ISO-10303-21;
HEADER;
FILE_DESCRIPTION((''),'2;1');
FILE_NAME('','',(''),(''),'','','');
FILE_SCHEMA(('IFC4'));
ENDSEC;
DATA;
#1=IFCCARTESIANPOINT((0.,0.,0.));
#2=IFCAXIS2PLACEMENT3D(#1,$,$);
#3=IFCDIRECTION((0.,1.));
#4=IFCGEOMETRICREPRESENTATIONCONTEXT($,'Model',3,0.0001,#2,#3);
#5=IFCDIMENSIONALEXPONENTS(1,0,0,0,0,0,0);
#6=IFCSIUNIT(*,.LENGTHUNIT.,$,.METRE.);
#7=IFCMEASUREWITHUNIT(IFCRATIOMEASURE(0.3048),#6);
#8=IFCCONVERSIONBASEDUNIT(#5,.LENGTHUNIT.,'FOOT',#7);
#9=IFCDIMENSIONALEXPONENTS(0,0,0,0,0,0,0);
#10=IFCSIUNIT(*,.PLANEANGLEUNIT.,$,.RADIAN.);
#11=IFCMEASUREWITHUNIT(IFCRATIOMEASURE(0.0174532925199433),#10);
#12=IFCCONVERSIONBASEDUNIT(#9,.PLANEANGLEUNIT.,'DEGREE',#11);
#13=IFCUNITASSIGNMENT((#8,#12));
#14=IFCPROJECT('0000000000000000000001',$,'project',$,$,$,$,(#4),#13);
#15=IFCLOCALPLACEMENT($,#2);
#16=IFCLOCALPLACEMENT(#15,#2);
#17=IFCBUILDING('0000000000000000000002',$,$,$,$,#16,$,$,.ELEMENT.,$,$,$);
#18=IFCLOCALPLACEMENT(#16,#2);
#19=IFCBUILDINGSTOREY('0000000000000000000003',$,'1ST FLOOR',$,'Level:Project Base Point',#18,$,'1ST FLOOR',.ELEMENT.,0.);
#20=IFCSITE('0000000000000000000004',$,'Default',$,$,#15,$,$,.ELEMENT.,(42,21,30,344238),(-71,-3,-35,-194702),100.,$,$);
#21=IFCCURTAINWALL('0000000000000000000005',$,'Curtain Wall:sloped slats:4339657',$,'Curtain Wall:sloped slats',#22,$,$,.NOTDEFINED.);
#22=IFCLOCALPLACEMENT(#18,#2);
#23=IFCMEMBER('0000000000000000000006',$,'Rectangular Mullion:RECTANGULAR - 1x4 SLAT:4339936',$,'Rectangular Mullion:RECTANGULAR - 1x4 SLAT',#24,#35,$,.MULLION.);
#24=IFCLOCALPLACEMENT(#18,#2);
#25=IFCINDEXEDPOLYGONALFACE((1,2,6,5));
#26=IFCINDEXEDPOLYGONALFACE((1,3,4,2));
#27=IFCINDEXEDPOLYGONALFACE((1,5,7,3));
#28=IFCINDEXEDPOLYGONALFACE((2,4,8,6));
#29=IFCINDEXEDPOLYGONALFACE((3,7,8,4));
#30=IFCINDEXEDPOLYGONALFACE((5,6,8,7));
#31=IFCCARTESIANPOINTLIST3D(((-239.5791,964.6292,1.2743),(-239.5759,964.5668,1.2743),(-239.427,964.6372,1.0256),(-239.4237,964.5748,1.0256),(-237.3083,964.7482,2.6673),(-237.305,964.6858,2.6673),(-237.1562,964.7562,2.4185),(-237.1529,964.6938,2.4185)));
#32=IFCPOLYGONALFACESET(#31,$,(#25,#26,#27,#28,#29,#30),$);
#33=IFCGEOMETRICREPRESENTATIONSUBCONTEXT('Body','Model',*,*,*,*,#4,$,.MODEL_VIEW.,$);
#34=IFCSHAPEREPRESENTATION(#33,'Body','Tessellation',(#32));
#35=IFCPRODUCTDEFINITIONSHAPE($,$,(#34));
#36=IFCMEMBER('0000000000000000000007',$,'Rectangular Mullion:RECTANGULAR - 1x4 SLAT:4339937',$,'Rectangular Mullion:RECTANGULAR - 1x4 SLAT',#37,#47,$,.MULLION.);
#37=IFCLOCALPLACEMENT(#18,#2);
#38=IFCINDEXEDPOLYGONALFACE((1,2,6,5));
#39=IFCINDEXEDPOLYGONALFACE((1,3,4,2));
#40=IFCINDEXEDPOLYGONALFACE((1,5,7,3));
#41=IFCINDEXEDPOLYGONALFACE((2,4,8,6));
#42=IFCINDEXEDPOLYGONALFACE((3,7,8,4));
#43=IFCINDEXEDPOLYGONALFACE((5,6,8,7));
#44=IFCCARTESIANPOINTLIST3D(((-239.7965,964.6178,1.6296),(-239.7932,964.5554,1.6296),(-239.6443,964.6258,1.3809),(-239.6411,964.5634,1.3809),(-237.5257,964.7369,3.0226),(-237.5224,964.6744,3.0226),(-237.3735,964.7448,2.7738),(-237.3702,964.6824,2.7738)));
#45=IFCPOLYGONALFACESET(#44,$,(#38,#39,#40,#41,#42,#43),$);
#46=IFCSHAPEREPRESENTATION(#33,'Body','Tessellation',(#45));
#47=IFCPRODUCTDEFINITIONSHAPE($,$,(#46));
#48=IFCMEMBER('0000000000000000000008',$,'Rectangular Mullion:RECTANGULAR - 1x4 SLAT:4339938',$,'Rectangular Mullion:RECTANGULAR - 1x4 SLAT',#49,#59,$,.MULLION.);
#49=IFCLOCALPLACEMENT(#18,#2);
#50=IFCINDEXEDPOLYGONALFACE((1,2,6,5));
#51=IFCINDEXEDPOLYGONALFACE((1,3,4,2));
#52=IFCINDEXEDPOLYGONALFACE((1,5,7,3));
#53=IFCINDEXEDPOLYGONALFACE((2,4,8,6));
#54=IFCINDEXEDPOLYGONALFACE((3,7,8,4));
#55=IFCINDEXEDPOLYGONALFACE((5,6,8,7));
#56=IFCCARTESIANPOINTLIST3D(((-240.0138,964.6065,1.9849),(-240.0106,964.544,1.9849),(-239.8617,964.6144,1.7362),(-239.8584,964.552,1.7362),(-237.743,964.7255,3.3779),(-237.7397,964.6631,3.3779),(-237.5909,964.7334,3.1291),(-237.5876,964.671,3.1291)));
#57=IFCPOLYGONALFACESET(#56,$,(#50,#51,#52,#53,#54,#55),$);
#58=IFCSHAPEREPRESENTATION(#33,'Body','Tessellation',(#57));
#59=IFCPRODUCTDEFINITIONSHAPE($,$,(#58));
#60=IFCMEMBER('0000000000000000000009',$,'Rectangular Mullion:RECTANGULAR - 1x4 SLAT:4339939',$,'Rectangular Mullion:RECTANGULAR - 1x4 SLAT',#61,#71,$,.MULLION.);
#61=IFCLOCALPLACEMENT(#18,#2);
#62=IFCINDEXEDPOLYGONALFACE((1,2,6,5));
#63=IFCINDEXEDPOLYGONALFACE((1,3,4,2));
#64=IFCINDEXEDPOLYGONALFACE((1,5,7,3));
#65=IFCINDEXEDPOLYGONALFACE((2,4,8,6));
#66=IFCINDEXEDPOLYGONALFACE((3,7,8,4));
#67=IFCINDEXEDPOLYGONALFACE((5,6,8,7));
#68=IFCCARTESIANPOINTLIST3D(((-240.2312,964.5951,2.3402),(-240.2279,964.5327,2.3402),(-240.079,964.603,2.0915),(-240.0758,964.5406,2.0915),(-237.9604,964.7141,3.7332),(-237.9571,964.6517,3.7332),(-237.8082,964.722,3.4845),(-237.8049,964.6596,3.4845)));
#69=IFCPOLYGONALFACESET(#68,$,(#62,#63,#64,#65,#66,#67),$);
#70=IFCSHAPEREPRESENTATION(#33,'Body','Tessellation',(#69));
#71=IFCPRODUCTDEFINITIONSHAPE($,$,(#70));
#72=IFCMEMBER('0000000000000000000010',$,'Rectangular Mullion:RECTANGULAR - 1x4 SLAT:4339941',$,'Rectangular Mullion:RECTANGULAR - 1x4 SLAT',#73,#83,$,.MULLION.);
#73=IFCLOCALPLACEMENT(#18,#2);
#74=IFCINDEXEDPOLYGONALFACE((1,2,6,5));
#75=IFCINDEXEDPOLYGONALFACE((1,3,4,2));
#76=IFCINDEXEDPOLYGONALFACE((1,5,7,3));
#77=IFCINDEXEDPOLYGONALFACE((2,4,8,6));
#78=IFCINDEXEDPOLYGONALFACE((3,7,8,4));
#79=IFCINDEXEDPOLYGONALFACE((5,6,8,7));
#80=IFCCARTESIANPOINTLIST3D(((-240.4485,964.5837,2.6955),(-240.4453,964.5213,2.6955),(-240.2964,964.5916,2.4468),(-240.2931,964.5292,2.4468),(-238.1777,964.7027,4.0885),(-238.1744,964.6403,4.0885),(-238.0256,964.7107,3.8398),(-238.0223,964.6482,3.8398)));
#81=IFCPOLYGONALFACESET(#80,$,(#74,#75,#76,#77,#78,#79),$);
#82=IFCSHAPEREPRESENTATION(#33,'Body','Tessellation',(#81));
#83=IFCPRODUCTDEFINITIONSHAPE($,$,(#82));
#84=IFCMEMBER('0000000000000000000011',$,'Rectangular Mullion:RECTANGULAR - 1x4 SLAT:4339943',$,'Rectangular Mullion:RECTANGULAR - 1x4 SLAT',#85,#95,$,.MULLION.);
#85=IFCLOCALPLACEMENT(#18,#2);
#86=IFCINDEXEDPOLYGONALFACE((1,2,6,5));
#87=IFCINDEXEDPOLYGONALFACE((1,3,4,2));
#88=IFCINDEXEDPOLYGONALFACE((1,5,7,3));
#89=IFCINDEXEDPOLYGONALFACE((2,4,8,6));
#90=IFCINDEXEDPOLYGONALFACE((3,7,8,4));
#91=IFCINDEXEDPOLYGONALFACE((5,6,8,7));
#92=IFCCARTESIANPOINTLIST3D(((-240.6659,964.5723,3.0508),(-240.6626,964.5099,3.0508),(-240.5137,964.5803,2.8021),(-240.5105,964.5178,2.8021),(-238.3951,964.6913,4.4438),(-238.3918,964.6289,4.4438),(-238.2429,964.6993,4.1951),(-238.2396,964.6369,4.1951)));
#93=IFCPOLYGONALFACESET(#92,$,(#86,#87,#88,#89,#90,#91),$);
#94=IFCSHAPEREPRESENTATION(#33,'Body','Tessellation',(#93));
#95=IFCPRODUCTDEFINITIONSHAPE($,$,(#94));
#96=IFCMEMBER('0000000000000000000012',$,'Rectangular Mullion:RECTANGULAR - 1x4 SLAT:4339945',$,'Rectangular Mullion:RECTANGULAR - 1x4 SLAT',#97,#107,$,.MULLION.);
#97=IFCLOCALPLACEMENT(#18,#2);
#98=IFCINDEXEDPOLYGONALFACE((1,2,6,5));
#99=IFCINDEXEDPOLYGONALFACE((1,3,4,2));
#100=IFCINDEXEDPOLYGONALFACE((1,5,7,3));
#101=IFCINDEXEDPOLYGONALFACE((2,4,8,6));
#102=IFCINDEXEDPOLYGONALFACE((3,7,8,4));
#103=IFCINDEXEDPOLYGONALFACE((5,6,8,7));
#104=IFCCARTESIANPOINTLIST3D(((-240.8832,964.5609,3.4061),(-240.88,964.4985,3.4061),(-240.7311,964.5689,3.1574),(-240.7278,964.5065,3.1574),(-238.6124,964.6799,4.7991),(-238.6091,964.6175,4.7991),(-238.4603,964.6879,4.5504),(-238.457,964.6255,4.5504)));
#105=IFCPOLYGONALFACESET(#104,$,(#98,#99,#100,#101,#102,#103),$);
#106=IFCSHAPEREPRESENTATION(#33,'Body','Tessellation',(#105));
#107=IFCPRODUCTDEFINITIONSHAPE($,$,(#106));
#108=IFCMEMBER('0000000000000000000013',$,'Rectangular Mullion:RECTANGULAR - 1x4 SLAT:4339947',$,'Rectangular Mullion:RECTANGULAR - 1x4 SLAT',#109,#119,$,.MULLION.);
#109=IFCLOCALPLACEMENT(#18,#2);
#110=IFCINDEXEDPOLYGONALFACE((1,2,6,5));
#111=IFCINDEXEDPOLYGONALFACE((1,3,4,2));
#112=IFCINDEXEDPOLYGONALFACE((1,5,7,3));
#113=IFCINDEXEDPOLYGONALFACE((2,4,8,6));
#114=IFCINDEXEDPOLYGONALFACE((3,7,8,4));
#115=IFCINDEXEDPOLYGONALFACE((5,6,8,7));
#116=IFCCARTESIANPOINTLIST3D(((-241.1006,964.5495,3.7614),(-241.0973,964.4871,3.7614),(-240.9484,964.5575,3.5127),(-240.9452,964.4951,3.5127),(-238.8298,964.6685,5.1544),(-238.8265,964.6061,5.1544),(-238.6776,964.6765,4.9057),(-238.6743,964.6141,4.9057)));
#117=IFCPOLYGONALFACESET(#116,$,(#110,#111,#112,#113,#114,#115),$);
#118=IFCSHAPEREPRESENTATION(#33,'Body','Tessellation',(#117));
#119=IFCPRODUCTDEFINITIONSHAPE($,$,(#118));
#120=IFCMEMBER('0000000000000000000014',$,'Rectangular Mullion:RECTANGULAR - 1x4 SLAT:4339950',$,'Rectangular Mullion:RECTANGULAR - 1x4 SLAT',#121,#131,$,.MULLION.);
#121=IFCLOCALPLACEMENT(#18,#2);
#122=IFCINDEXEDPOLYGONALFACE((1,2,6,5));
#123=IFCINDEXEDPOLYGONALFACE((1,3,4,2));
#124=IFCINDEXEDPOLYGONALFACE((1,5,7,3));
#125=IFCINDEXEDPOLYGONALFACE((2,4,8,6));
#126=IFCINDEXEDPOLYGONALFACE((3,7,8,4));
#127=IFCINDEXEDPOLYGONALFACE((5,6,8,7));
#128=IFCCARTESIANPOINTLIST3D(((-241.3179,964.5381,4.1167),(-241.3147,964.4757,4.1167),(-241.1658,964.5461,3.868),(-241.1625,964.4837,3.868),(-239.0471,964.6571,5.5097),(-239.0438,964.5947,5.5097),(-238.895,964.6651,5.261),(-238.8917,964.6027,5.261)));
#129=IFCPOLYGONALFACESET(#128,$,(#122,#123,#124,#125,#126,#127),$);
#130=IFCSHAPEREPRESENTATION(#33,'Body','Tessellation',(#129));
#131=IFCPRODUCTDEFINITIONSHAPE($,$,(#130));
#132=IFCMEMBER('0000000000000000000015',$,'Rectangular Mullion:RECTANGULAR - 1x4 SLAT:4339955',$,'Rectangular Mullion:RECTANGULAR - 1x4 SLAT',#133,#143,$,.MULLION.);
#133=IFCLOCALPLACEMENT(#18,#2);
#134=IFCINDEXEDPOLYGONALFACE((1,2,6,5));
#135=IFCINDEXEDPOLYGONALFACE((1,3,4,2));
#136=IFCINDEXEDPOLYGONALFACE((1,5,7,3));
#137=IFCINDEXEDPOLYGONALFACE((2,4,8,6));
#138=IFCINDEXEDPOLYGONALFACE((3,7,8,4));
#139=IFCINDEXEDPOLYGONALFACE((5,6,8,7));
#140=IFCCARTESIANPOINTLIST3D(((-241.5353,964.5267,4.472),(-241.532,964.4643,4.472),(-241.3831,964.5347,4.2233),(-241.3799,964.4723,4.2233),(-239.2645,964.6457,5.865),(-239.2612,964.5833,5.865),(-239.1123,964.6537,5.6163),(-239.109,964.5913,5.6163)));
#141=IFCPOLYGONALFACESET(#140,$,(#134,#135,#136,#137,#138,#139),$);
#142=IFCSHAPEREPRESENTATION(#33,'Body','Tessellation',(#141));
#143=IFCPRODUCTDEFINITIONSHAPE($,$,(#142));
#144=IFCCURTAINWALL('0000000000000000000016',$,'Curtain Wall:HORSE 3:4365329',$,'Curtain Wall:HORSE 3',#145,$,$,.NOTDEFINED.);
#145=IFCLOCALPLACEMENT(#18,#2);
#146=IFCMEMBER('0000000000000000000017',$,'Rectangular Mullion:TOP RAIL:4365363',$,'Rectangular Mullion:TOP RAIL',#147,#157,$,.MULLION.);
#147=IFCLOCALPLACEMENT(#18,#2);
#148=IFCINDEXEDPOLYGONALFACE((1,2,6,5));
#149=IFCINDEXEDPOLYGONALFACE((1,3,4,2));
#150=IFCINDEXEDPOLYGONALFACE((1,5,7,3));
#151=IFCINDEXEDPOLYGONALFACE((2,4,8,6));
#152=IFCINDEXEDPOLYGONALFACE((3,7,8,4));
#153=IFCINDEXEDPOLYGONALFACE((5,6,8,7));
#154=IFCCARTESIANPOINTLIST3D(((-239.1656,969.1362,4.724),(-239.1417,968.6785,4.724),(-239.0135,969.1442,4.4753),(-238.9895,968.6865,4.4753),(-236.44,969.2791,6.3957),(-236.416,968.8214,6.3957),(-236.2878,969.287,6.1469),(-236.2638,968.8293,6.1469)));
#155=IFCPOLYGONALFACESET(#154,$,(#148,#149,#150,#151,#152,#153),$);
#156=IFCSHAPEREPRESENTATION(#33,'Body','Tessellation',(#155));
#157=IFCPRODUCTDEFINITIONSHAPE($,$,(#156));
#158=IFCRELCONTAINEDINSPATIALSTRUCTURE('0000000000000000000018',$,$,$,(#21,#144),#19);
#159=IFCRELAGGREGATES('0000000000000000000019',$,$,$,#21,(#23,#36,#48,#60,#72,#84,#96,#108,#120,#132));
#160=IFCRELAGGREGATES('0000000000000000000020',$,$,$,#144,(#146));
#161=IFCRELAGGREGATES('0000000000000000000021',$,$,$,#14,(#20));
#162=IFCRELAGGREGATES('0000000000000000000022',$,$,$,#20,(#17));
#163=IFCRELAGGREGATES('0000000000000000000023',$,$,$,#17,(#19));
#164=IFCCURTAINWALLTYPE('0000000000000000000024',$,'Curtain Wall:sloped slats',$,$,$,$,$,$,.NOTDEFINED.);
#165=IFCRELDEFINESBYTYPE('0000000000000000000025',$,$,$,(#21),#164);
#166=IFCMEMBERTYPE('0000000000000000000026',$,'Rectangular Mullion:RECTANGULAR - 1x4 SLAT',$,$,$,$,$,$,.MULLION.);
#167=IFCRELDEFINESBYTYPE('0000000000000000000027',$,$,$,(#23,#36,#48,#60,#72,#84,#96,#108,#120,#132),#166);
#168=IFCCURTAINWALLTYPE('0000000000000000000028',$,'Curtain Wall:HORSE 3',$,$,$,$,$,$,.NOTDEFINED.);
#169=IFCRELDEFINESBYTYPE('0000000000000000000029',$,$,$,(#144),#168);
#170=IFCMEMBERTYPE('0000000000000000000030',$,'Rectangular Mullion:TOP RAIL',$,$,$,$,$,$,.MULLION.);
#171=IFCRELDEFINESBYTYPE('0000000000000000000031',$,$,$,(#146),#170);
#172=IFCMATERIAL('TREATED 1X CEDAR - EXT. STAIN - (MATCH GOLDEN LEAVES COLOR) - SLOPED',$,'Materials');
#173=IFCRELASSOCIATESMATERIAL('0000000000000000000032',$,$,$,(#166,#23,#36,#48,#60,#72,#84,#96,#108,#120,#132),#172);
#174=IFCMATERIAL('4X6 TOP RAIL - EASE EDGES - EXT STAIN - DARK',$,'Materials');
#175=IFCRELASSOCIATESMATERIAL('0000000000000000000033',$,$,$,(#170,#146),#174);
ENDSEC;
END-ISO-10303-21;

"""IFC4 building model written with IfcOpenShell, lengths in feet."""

from ifc_helpers import new_model, entity, si_unit, converted_unit, direction, frame, frame_2d, origin, origin_2d_with_axis, place, context, subcontext, project, spatial, rectangle, extrude, source, transform, mapped, material, material_profile, profile_set, profile_usage, type_object, type_shapes, element, aggregate, save


model = new_model("IFC4")

# Units and contexts
model_context = context("Model", 3, precision=0.0001, world=origin(), true_north=direction((0.0, 1.0)))
body_context = subcontext(model_context, "Body", "Model", "MODEL_VIEW")
ifc_project = project(units=[converted_unit("LENGTHUNIT", "FOOT", entity("IfcRatioMeasure", 0.3048), si_unit("LENGTHUNIT", "METRE"), dimensions=[1, 0, 0, 0, 0, 0, 0]), converted_unit("PLANEANGLEUNIT", "DEGREE", entity("IfcRatioMeasure", 0.0174532925199433), si_unit("PLANEANGLEUNIT", "RADIAN"), dimensions=[0, 0, 0, 0, 0, 0, 0])], contexts=[model_context])

# Site, building, storey
site_placement = place(None, origin())
site = spatial("IfcSite", under=ifc_project, at=site_placement, Name="Default", CompositionType="ELEMENT", RefLatitude=(42, 21, 30, 344238), RefLongitude=(-71, -3, -35, -194702), RefElevation=100.0)
building_placement = place(site_placement, origin())
building = spatial("IfcBuilding", under=site, at=building_placement, CompositionType="ELEMENT")
storey_placement = place(building_placement, origin())
storey = spatial("IfcBuildingStorey", under=building, at=storey_placement, Name="1ST FLOOR", ObjectType="Level:Project Base Point", LongName="1ST FLOOR", CompositionType="ELEMENT", Elevation=0.0)

# Curtain wall, members
curtain_wall_type_1 = type_object("IfcCurtainWallType", Name="Curtain Wall:sloped slats", PredefinedType="NOTDEFINED")
curtain_wall_1_placement = place(storey_placement, origin())
curtain_wall_1 = element("IfcCurtainWall", 1, at=curtain_wall_1_placement, inside=storey, type_object=curtain_wall_type_1, Name="Curtain Wall:sloped slats:4339657", ObjectType="Curtain Wall:sloped slats", PredefinedType="NOTDEFINED")
ifc_material_1 = material(Name="TREATED 1X CEDAR - EXT. STAIN - (MATCH GOLDEN LEAVES COLOR) - SLOPED", Category="Materials")
ifc_material_profile_1 = material_profile(ifc_material_1, rectangle(XDim=0.0625, YDim=0.2917, at=frame_2d((0.0, 0.0), x_axis=(1.0, 0.0))), Name="RECTANGULAR - 1x4 SLAT")
ifc_profile_set_1 = profile_set([ifc_material_profile_1], Name="RECTANGULAR - 1x4 SLAT")
ifc_profile_usage_1 = profile_usage(ifc_profile_set_1)
member_type_1 = type_object("IfcMemberType", Name="Rectangular Mullion:RECTANGULAR - 1x4 SLAT", PredefinedType="MULLION", material=ifc_profile_set_1)
shared_shape_1 = source(origin(), body_context, "Body", "SweptSolid", [
    extrude(rectangle(XDim=0.0625, YDim=0.2917, at=frame_2d((0.0, 0.0), x_axis=(1.0, 0.0))), frame((0.0, 0.0, -2.6667), z_axis=(0.0, 0.0, 1.0), x_axis=(0.0, -1.0, 0.0)), (0.0, 0.0, 1.0), 2.6667),
])
type_shapes(member_type_1, [shared_shape_1])
member_1_placement = place(storey_placement, frame((-239.5014, 964.602, 1.1499), z_axis=(-0.851559, -0.044628, -0.522356), x_axis=(-0.52164, -0.027338, 0.852727)))
member_1 = element("IfcMember", 2, at=member_1_placement, type_object=member_type_1, material=ifc_profile_usage_1, Name="Rectangular Mullion:RECTANGULAR - 1x4 SLAT:4339936", ObjectType="Rectangular Mullion:RECTANGULAR - 1x4 SLAT", PredefinedType="MULLION", context=body_context, shape_type="MappedRepresentation", body=[
    mapped(shared_shape_1, transform((0.0, 0.0, 0.0), scale=1.0)),
])
ifc_profile_usage_2 = profile_usage(ifc_profile_set_1)
member_2_placement = place(storey_placement, frame((-239.7188, 964.5906, 1.5053), z_axis=(-0.851559, -0.044628, -0.522356), x_axis=(-0.52164, -0.027338, 0.852727)))
member_2 = element("IfcMember", 3, at=member_2_placement, type_object=member_type_1, material=ifc_profile_usage_2, Name="Rectangular Mullion:RECTANGULAR - 1x4 SLAT:4339937", ObjectType="Rectangular Mullion:RECTANGULAR - 1x4 SLAT", PredefinedType="MULLION", context=body_context, shape_type="MappedRepresentation", body=[
    mapped(shared_shape_1, transform((0.0, 0.0, 0.0), scale=1.0)),
])
ifc_profile_usage_3 = profile_usage(ifc_profile_set_1)
member_3_placement = place(storey_placement, frame((-239.9361, 964.5792, 1.8606), z_axis=(-0.851559, -0.044628, -0.522356), x_axis=(-0.52164, -0.027338, 0.852727)))
member_3 = element("IfcMember", 4, at=member_3_placement, type_object=member_type_1, material=ifc_profile_usage_3, Name="Rectangular Mullion:RECTANGULAR - 1x4 SLAT:4339938", ObjectType="Rectangular Mullion:RECTANGULAR - 1x4 SLAT", PredefinedType="MULLION", context=body_context, shape_type="MappedRepresentation", body=[
    mapped(shared_shape_1, transform((0.0, 0.0, 0.0), scale=1.0)),
])
ifc_profile_usage_4 = profile_usage(ifc_profile_set_1)
member_4_placement = place(storey_placement, frame((-240.1535, 964.5678, 2.2159), z_axis=(-0.851559, -0.044628, -0.522356), x_axis=(-0.52164, -0.027338, 0.852727)))
member_4 = element("IfcMember", 5, at=member_4_placement, type_object=member_type_1, material=ifc_profile_usage_4, Name="Rectangular Mullion:RECTANGULAR - 1x4 SLAT:4339939", ObjectType="Rectangular Mullion:RECTANGULAR - 1x4 SLAT", PredefinedType="MULLION", context=body_context, shape_type="MappedRepresentation", body=[
    mapped(shared_shape_1, transform((0.0, 0.0, 0.0), scale=1.0)),
])
ifc_profile_usage_5 = profile_usage(ifc_profile_set_1)
member_5_placement = place(storey_placement, frame((-240.3708, 964.5565, 2.5712), z_axis=(-0.851559, -0.044628, -0.522356), x_axis=(-0.52164, -0.027338, 0.852727)))
member_5 = element("IfcMember", 6, at=member_5_placement, type_object=member_type_1, material=ifc_profile_usage_5, Name="Rectangular Mullion:RECTANGULAR - 1x4 SLAT:4339941", ObjectType="Rectangular Mullion:RECTANGULAR - 1x4 SLAT", PredefinedType="MULLION", context=body_context, shape_type="MappedRepresentation", body=[
    mapped(shared_shape_1, transform((0.0, 0.0, 0.0), scale=1.0)),
])
ifc_profile_usage_6 = profile_usage(ifc_profile_set_1)
member_6_placement = place(storey_placement, frame((-240.5882, 964.5451, 2.9265), z_axis=(-0.851559, -0.044628, -0.522356), x_axis=(-0.52164, -0.027338, 0.852727)))
member_6 = element("IfcMember", 7, at=member_6_placement, type_object=member_type_1, material=ifc_profile_usage_6, Name="Rectangular Mullion:RECTANGULAR - 1x4 SLAT:4339943", ObjectType="Rectangular Mullion:RECTANGULAR - 1x4 SLAT", PredefinedType="MULLION", context=body_context, shape_type="MappedRepresentation", body=[
    mapped(shared_shape_1, transform((0.0, 0.0, 0.0), scale=1.0)),
])
ifc_profile_usage_7 = profile_usage(ifc_profile_set_1)
member_7_placement = place(storey_placement, frame((-240.8055, 964.5337, 3.2818), z_axis=(-0.851559, -0.044628, -0.522356), x_axis=(-0.52164, -0.027338, 0.852727)))
member_7 = element("IfcMember", 8, at=member_7_placement, type_object=member_type_1, material=ifc_profile_usage_7, Name="Rectangular Mullion:RECTANGULAR - 1x4 SLAT:4339945", ObjectType="Rectangular Mullion:RECTANGULAR - 1x4 SLAT", PredefinedType="MULLION", context=body_context, shape_type="MappedRepresentation", body=[
    mapped(shared_shape_1, transform((0.0, 0.0, 0.0), scale=1.0)),
])
ifc_profile_usage_8 = profile_usage(ifc_profile_set_1)
member_8_placement = place(storey_placement, frame((-241.0229, 964.5223, 3.6371), z_axis=(-0.851559, -0.044628, -0.522356), x_axis=(-0.52164, -0.027338, 0.852727)))
member_8 = element("IfcMember", 9, at=member_8_placement, type_object=member_type_1, material=ifc_profile_usage_8, Name="Rectangular Mullion:RECTANGULAR - 1x4 SLAT:4339947", ObjectType="Rectangular Mullion:RECTANGULAR - 1x4 SLAT", PredefinedType="MULLION", context=body_context, shape_type="MappedRepresentation", body=[
    mapped(shared_shape_1, transform((0.0, 0.0, 0.0), scale=1.0)),
])
ifc_profile_usage_9 = profile_usage(ifc_profile_set_1)
member_9_placement = place(storey_placement, frame((-241.2402, 964.5109, 3.9924), z_axis=(-0.851559, -0.044628, -0.522356), x_axis=(-0.52164, -0.027338, 0.852727)))
member_9 = element("IfcMember", 10, at=member_9_placement, type_object=member_type_1, material=ifc_profile_usage_9, Name="Rectangular Mullion:RECTANGULAR - 1x4 SLAT:4339950", ObjectType="Rectangular Mullion:RECTANGULAR - 1x4 SLAT", PredefinedType="MULLION", context=body_context, shape_type="MappedRepresentation", body=[
    mapped(shared_shape_1, transform((0.0, 0.0, 0.0), scale=1.0)),
])
ifc_profile_usage_10 = profile_usage(ifc_profile_set_1)
member_10_placement = place(storey_placement, frame((-241.4576, 964.4995, 4.3477), z_axis=(-0.851559, -0.044628, -0.522356), x_axis=(-0.52164, -0.027338, 0.852727)))
member_10 = element("IfcMember", 11, at=member_10_placement, type_object=member_type_1, material=ifc_profile_usage_10, Name="Rectangular Mullion:RECTANGULAR - 1x4 SLAT:4339955", ObjectType="Rectangular Mullion:RECTANGULAR - 1x4 SLAT", PredefinedType="MULLION", context=body_context, shape_type="MappedRepresentation", body=[
    mapped(shared_shape_1, transform((0.0, 0.0, 0.0), scale=1.0)),
])
aggregate(curtain_wall_1, [member_1, member_2, member_3, member_4, member_5, member_6, member_7, member_8, member_9, member_10])

# Curtain wall, member
curtain_wall_type_2 = type_object("IfcCurtainWallType", Name="Curtain Wall:HORSE 3", PredefinedType="NOTDEFINED")
curtain_wall_2_placement = place(storey_placement, origin())
curtain_wall_2 = element("IfcCurtainWall", 12, at=curtain_wall_2_placement, inside=storey, type_object=curtain_wall_type_2, Name="Curtain Wall:HORSE 3:4365329", ObjectType="Curtain Wall:HORSE 3", PredefinedType="NOTDEFINED")
ifc_material_2 = material(Name="4X6 TOP RAIL - EASE EDGES - EXT STAIN - DARK", Category="Materials")
ifc_material_profile_2 = material_profile(ifc_material_2, rectangle(XDim=0.4583, YDim=0.2917, at=origin_2d_with_axis()), Name="TOP RAIL")
ifc_profile_set_2 = profile_set([ifc_material_profile_2], Name="TOP RAIL")
ifc_profile_usage_11 = profile_usage(ifc_profile_set_2)
member_type_2 = type_object("IfcMemberType", Name="Rectangular Mullion:TOP RAIL", PredefinedType="MULLION", material=ifc_profile_set_2)
shared_shape_2 = source(origin(), body_context, "Body", "SweptSolid", [
    extrude(rectangle(XDim=0.4583, YDim=0.2917, at=frame_2d((0.0, 0.0), x_axis=(1.0, 0.0))), frame((-0.1458, 0.0625, -3.2006), z_axis=(0.0, 0.0, 1.0), x_axis=(0.0, -1.0, 0.0)), (0.0, 0.0, 1.0), 3.2006),
])
type_shapes(member_type_2, [shared_shape_2])
member_11_placement = place(storey_placement, frame((-239.1504, 968.845, 4.724), z_axis=(-0.851606, -0.044631, -0.522279), x_axis=(-0.521563, -0.027334, 0.852775)))
member_11 = element("IfcMember", 13, at=member_11_placement, type_object=member_type_2, material=ifc_profile_usage_11, Name="Rectangular Mullion:TOP RAIL:4365363", ObjectType="Rectangular Mullion:TOP RAIL", PredefinedType="MULLION", context=body_context, shape_type="MappedRepresentation", body=[
    mapped(shared_shape_2, transform((0.0, 0.0, 0.0), scale=1.0)),
])
aggregate(curtain_wall_2, [member_11])

save(model, "model.ifc")
